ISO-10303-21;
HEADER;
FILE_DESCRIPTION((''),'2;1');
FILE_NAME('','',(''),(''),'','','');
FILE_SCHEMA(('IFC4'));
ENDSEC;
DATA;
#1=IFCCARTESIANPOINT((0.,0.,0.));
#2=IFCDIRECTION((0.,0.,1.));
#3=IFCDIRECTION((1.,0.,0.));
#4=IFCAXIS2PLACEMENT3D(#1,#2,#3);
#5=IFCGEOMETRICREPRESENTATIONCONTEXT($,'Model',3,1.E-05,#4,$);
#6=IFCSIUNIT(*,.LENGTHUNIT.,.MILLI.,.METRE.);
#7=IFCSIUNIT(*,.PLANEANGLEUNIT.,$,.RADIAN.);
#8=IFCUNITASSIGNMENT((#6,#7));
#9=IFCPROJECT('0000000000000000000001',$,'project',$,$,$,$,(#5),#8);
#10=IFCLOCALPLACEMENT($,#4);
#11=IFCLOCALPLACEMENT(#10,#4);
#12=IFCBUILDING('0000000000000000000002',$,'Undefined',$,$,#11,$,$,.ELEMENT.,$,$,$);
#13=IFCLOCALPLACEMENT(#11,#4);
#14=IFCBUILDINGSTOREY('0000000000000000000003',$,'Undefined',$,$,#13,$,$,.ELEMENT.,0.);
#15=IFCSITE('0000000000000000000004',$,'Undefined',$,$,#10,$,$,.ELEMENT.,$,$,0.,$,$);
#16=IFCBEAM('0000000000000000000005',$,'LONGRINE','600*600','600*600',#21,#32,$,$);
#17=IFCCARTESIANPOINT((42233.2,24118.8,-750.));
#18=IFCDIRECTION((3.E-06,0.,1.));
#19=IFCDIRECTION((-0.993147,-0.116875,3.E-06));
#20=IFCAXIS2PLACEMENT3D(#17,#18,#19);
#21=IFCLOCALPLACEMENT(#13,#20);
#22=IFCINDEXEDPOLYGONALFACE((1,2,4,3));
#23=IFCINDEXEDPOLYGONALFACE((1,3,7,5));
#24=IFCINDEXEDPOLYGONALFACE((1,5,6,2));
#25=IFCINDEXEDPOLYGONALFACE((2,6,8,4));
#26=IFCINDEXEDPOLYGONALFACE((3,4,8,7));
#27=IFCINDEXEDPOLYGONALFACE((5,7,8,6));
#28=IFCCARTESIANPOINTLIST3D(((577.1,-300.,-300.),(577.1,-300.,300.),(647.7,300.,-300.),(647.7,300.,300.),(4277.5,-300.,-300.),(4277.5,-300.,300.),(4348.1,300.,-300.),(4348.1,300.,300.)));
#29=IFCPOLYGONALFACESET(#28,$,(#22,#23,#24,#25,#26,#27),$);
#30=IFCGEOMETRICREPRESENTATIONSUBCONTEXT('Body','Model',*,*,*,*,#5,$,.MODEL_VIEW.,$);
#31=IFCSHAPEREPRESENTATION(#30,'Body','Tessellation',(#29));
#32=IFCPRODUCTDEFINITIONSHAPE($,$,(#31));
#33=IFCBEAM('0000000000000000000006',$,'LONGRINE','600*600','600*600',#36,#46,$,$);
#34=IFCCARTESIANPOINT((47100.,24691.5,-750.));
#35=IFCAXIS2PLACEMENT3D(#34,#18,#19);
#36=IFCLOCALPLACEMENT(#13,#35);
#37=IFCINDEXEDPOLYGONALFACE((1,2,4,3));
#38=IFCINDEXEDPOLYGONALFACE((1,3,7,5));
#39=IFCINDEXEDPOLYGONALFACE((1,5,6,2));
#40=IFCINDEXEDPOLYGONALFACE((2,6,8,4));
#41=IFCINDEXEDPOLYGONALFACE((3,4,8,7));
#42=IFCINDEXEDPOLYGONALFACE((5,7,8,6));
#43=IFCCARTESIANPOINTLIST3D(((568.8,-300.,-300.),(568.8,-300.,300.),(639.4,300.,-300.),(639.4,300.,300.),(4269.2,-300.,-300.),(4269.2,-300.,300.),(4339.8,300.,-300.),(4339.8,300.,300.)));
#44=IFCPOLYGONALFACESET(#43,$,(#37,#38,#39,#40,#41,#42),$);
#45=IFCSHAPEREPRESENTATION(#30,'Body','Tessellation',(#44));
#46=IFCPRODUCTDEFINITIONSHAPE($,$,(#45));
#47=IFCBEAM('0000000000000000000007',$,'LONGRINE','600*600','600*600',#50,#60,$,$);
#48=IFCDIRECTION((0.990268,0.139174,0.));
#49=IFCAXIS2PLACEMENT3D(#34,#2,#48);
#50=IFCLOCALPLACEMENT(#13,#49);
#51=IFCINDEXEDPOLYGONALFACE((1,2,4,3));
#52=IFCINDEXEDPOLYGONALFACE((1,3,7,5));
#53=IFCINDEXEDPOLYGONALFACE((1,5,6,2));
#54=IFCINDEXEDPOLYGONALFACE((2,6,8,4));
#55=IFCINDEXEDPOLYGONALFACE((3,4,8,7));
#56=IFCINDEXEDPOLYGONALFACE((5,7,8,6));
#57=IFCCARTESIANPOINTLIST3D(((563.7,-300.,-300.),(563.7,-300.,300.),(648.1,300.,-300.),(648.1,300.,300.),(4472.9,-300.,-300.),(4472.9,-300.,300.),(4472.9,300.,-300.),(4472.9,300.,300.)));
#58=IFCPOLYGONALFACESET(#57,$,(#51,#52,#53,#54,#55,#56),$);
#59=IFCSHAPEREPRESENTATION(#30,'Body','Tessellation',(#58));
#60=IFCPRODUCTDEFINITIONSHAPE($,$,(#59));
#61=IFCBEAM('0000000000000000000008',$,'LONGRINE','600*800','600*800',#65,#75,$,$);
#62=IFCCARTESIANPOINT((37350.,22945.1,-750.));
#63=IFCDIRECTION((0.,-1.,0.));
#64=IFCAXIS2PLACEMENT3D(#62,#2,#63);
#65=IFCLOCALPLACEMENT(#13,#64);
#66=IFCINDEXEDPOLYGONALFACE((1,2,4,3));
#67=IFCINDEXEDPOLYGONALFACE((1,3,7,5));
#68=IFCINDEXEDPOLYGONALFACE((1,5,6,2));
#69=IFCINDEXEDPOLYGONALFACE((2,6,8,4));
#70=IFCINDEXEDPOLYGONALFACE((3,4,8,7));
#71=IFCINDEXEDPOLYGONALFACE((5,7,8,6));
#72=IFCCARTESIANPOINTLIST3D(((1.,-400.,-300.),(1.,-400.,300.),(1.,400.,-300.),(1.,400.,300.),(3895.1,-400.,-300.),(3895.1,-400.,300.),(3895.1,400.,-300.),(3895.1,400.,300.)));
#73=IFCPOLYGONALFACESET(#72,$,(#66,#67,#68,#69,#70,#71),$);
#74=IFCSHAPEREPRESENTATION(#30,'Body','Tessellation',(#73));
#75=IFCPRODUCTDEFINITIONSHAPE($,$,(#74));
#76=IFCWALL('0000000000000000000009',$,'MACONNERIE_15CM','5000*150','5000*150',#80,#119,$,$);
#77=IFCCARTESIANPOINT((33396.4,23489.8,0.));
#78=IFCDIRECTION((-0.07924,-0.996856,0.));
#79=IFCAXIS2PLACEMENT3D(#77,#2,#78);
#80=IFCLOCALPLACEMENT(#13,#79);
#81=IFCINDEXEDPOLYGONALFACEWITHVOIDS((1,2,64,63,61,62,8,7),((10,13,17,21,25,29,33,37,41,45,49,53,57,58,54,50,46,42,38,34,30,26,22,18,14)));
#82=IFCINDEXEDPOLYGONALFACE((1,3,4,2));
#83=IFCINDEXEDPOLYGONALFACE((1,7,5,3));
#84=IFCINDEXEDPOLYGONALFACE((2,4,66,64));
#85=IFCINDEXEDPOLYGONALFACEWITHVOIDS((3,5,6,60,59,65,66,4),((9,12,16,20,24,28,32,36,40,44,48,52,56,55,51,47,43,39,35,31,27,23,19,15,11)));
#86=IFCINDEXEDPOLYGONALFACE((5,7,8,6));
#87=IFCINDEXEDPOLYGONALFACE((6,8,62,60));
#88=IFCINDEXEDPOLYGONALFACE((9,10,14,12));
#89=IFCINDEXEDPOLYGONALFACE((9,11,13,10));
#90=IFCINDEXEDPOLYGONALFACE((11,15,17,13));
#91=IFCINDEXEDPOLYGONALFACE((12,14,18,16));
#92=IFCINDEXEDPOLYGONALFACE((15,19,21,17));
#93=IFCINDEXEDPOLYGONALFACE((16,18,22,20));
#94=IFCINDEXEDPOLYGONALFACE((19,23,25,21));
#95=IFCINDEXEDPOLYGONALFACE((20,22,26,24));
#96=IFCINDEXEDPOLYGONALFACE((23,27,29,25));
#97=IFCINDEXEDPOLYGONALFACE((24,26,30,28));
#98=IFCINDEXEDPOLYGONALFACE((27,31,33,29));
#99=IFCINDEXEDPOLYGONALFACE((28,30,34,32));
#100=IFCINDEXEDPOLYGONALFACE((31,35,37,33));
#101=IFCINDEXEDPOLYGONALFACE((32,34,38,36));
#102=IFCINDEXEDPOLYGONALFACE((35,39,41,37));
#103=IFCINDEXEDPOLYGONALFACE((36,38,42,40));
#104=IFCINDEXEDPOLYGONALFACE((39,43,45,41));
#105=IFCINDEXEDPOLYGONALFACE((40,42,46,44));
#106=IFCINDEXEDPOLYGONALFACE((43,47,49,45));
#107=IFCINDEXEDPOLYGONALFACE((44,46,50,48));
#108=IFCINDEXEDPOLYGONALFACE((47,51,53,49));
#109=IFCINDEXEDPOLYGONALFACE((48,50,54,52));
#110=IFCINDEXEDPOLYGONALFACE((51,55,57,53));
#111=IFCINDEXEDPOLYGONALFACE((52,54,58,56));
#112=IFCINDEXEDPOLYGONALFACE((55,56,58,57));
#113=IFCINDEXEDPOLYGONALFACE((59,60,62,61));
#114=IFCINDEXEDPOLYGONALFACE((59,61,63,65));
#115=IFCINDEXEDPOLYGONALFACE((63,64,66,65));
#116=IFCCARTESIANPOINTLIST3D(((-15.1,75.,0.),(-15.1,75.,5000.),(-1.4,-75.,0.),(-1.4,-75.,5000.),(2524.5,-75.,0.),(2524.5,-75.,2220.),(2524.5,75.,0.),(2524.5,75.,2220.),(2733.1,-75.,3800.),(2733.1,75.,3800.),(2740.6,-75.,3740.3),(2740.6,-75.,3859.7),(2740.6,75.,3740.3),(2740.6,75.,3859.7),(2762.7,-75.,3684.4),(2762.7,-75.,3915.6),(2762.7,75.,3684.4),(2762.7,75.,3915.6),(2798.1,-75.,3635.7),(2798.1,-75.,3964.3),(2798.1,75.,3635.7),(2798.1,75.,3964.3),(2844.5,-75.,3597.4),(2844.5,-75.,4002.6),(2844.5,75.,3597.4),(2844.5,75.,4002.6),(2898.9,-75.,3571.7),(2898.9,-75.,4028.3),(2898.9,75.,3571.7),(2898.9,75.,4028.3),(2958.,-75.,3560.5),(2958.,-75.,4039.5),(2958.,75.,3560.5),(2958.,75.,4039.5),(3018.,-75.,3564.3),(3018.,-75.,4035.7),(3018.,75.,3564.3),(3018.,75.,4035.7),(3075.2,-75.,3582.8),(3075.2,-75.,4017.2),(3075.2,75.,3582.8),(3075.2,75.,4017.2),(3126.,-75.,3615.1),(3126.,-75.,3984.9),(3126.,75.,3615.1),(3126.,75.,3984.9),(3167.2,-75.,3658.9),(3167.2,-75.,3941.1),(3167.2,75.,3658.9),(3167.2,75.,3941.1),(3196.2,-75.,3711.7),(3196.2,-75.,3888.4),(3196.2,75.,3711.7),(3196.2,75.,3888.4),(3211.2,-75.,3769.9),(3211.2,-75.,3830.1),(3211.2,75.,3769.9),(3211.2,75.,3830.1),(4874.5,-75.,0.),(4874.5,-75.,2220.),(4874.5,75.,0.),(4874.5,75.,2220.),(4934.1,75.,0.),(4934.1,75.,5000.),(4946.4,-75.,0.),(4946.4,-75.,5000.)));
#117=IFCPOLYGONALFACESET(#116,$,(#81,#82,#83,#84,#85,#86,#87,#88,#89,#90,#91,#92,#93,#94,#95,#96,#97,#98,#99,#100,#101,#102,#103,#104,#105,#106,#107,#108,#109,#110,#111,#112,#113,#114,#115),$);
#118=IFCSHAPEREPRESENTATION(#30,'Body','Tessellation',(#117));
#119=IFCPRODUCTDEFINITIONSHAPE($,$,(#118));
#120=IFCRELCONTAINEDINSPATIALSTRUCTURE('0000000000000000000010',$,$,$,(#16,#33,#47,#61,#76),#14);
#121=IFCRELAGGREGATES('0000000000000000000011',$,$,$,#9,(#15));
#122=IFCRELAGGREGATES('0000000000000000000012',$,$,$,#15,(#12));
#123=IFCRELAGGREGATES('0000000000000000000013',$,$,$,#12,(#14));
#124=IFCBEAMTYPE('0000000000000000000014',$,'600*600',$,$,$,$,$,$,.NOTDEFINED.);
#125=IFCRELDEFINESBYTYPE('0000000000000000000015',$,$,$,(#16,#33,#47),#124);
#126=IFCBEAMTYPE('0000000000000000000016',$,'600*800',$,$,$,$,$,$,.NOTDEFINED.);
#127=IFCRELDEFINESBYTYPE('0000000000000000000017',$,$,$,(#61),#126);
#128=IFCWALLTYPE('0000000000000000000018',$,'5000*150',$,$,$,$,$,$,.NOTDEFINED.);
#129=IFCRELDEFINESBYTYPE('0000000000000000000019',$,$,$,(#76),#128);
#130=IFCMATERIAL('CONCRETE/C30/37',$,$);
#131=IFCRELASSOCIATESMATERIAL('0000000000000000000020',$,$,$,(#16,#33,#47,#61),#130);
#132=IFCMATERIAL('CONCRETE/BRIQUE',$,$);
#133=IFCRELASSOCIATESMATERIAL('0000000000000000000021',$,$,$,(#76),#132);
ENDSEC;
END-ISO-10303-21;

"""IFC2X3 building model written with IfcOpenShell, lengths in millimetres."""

from ifc_helpers import new_model, si_unit, frame, frame_2d, origin_with_axes, origin_2d_with_axis, place, context, subcontext, project, spatial, polyline, rectangle, circle, outline, extrude, boolean, clip, halfspace, material, type_object, element, save


model = new_model("IFC2X3")

# Units and contexts
model_context = context("Model", 3, precision=1e-05, world=origin_with_axes())
body_context = subcontext(model_context, "Body", "Model", "MODEL_VIEW")
ifc_project = project(units=[si_unit("LENGTHUNIT", "METRE", prefix="MILLI"), si_unit("PLANEANGLEUNIT", "RADIAN")], contexts=[model_context])

# Site, building, storey
site_placement = place(None, origin_with_axes())
site = spatial("IfcSite", under=ifc_project, at=site_placement, Name="Undefined", CompositionType="ELEMENT", RefElevation=0.0)
building_placement = place(site_placement, origin_with_axes())
building = spatial("IfcBuilding", under=site, at=building_placement, Name="Undefined", CompositionType="ELEMENT")
storey_placement = place(building_placement, origin_with_axes())
storey = spatial("IfcBuildingStorey", under=building, at=storey_placement, Name="Undefined", CompositionType="ELEMENT", Elevation=0.0)

# Shared definitions
ifc_material_1 = material(Name="CONCRETE/C30/37")

# Beams
beam_type_1 = type_object("IfcBeamType", Name="600*600", PredefinedType="NOTDEFINED")
beam_1_placement = place(storey_placement, frame((42233.2, 24118.8, -750.0), z_axis=(0.000003, 0.0, 1.0), x_axis=(-0.993147, -0.116875, 0.000003)))
element("IfcBeam", 1, at=beam_1_placement, inside=storey, type_object=beam_type_1, material=ifc_material_1, Name="LONGRINE", Description="600*600", ObjectType="600*600", context=body_context, shape_type="Clipping", body=[
    clip(clip(extrude(rectangle(XDim=600.0, YDim=600.0, at=origin_2d_with_axis()), frame((4384.1, 0.0, 0.0), z_axis=(-1.0, 0.0, 0.0), x_axis=(0.0, -1.0, 0.0)), (0.0, 0.0, 1.0), 3843.0), halfspace(frame((4312.8, 0.0, -1000.0), z_axis=(-0.993147, 0.116875, 0.000003), x_axis=(0.116875, 0.993147, 0.0)), True)), halfspace(frame((612.4, 0.0, -1000.0), z_axis=(0.993147, -0.116875, -0.000003), x_axis=(-0.116875, -0.993147, 0.0)), True)),
])
beam_2_placement = place(storey_placement, frame((47100.0, 24691.5, -750.0), z_axis=(0.000003, 0.0, 1.0), x_axis=(-0.993147, -0.116875, 0.000003)))
element("IfcBeam", 2, at=beam_2_placement, inside=storey, type_object=beam_type_1, material=ifc_material_1, Name="LONGRINE", Description="600*600", ObjectType="600*600", context=body_context, shape_type="Clipping", body=[
    clip(clip(extrude(rectangle(XDim=600.0, YDim=600.0, at=origin_2d_with_axis()), frame((4375.8, 0.0, 0.0), z_axis=(-1.0, 0.0, 0.0), x_axis=(0.0, -1.0, 0.0)), (0.0, 0.0, 1.0), 3843.0), halfspace(frame((4304.5, 0.0, -1000.0), z_axis=(-0.993147, 0.116875, 0.000003), x_axis=(0.116875, 0.993147, 0.0)), True)), halfspace(frame((604.1, 0.0, -1000.0), z_axis=(0.993147, -0.116875, -0.000003), x_axis=(-0.116875, -0.993147, 0.0)), True)),
])
beam_3_placement = place(storey_placement, frame((47100.0, 24691.5, -750.0), z_axis=(0.0, 0.0, 1.0), x_axis=(0.990268, 0.139174, 0.0)))
element("IfcBeam", 3, at=beam_3_placement, inside=storey, type_object=beam_type_1, material=ifc_material_1, Name="LONGRINE", Description="600*600", ObjectType="600*600", context=body_context, shape_type="Clipping", body=[
    clip(extrude(rectangle(XDim=600.0, YDim=600.0, at=origin_2d_with_axis()), frame((4472.9, 0.0, 0.0), z_axis=(-1.0, 0.0, 0.0), x_axis=(0.0, -1.0, 0.0)), (0.0, 0.0, 1.0), 3993.1), halfspace(frame((605.9, 0.0, -1000.0), z_axis=(0.990268, -0.139173, 0.0), x_axis=(-0.139173, -0.990268, 0.0)), True)),
])
beam_type_2 = type_object("IfcBeamType", Name="600*800", PredefinedType="NOTDEFINED")
beam_4_placement = place(storey_placement, frame((37350.0, 22945.1, -750.0), z_axis=(0.0, 0.0, 1.0), x_axis=(0.0, -1.0, 0.0)))
element("IfcBeam", 4, at=beam_4_placement, inside=storey, type_object=beam_type_2, material=ifc_material_1, Name="LONGRINE", Description="600*800", ObjectType="600*800", context=body_context, shape_type="SweptSolid", body=[
    extrude(rectangle(XDim=800.0, YDim=600.0, at=origin_2d_with_axis()), frame((3895.1, 0.0, 0.0), z_axis=(-1.0, 0.0, 0.0), x_axis=(0.0, -1.0, 0.0)), (0.0, 0.0, 1.0), 3894.1),
])

# Wall
ifc_material_2 = material(Name="CONCRETE/BRIQUE")
wall_type_1 = type_object("IfcWallType", Name="5000*150", PredefinedType="NOTDEFINED")
wall_1_placement = place(storey_placement, frame((33396.4, 23489.8, 0.0), z_axis=(0.0, 0.0, 1.0), x_axis=(-0.07924, -0.996856, 0.0)))
element("IfcWall", 5, at=wall_1_placement, inside=storey, type_object=wall_type_1, material=ifc_material_2, Name="MACONNERIE_15CM", Description="5000*150", ObjectType="5000*150", context=body_context, shape_type="CSG", body=[
    boolean("DIFFERENCE", boolean("DIFFERENCE", boolean("DIFFERENCE", boolean("DIFFERENCE", extrude(rectangle(XDim=5005.5, YDim=150.0, at=frame_2d((0.0, 2466.0), x_axis=(0.0, -1.0))), frame((0.0, 0.0, 0.0), z_axis=(0.0, 0.0, 1.0), x_axis=(0.0, -1.0, 0.0)), (0.0, 0.0, 1.0), 5000.0), extrude(circle(Radius=240.0, at=origin_2d_with_axis()), frame((2973.1, -85.0, 3800.0), z_axis=(0.0, 1.0, 0.0), x_axis=(-1.0, 0.0, 0.0)), (0.0, 0.0, 1.0), 170.0)), extrude(outline(polyline([(0.0, 0.0), (2220.0, 0.0), (2220.0, 2350.0), (0.0, 2350.0), (0.0, 0.0)])), frame((2524.5, 85.0, 2220.0), z_axis=(0.0, -1.0, 0.0), x_axis=(0.0, 0.0, -1.0)), (0.0, 0.0, 1.0), 170.0)), halfspace(frame((4940.3, 0.0, 1500.0), z_axis=(-0.996669, -0.081553, 0.0), x_axis=(-0.081553, 0.996669, 0.0)), True)), halfspace(frame((-8.2, 0.0, 1500.0), z_axis=(0.995883, 0.090651, 0.0), x_axis=(0.090651, -0.995883, 0.0)), True)),
])

save(model, "model.ifc")
